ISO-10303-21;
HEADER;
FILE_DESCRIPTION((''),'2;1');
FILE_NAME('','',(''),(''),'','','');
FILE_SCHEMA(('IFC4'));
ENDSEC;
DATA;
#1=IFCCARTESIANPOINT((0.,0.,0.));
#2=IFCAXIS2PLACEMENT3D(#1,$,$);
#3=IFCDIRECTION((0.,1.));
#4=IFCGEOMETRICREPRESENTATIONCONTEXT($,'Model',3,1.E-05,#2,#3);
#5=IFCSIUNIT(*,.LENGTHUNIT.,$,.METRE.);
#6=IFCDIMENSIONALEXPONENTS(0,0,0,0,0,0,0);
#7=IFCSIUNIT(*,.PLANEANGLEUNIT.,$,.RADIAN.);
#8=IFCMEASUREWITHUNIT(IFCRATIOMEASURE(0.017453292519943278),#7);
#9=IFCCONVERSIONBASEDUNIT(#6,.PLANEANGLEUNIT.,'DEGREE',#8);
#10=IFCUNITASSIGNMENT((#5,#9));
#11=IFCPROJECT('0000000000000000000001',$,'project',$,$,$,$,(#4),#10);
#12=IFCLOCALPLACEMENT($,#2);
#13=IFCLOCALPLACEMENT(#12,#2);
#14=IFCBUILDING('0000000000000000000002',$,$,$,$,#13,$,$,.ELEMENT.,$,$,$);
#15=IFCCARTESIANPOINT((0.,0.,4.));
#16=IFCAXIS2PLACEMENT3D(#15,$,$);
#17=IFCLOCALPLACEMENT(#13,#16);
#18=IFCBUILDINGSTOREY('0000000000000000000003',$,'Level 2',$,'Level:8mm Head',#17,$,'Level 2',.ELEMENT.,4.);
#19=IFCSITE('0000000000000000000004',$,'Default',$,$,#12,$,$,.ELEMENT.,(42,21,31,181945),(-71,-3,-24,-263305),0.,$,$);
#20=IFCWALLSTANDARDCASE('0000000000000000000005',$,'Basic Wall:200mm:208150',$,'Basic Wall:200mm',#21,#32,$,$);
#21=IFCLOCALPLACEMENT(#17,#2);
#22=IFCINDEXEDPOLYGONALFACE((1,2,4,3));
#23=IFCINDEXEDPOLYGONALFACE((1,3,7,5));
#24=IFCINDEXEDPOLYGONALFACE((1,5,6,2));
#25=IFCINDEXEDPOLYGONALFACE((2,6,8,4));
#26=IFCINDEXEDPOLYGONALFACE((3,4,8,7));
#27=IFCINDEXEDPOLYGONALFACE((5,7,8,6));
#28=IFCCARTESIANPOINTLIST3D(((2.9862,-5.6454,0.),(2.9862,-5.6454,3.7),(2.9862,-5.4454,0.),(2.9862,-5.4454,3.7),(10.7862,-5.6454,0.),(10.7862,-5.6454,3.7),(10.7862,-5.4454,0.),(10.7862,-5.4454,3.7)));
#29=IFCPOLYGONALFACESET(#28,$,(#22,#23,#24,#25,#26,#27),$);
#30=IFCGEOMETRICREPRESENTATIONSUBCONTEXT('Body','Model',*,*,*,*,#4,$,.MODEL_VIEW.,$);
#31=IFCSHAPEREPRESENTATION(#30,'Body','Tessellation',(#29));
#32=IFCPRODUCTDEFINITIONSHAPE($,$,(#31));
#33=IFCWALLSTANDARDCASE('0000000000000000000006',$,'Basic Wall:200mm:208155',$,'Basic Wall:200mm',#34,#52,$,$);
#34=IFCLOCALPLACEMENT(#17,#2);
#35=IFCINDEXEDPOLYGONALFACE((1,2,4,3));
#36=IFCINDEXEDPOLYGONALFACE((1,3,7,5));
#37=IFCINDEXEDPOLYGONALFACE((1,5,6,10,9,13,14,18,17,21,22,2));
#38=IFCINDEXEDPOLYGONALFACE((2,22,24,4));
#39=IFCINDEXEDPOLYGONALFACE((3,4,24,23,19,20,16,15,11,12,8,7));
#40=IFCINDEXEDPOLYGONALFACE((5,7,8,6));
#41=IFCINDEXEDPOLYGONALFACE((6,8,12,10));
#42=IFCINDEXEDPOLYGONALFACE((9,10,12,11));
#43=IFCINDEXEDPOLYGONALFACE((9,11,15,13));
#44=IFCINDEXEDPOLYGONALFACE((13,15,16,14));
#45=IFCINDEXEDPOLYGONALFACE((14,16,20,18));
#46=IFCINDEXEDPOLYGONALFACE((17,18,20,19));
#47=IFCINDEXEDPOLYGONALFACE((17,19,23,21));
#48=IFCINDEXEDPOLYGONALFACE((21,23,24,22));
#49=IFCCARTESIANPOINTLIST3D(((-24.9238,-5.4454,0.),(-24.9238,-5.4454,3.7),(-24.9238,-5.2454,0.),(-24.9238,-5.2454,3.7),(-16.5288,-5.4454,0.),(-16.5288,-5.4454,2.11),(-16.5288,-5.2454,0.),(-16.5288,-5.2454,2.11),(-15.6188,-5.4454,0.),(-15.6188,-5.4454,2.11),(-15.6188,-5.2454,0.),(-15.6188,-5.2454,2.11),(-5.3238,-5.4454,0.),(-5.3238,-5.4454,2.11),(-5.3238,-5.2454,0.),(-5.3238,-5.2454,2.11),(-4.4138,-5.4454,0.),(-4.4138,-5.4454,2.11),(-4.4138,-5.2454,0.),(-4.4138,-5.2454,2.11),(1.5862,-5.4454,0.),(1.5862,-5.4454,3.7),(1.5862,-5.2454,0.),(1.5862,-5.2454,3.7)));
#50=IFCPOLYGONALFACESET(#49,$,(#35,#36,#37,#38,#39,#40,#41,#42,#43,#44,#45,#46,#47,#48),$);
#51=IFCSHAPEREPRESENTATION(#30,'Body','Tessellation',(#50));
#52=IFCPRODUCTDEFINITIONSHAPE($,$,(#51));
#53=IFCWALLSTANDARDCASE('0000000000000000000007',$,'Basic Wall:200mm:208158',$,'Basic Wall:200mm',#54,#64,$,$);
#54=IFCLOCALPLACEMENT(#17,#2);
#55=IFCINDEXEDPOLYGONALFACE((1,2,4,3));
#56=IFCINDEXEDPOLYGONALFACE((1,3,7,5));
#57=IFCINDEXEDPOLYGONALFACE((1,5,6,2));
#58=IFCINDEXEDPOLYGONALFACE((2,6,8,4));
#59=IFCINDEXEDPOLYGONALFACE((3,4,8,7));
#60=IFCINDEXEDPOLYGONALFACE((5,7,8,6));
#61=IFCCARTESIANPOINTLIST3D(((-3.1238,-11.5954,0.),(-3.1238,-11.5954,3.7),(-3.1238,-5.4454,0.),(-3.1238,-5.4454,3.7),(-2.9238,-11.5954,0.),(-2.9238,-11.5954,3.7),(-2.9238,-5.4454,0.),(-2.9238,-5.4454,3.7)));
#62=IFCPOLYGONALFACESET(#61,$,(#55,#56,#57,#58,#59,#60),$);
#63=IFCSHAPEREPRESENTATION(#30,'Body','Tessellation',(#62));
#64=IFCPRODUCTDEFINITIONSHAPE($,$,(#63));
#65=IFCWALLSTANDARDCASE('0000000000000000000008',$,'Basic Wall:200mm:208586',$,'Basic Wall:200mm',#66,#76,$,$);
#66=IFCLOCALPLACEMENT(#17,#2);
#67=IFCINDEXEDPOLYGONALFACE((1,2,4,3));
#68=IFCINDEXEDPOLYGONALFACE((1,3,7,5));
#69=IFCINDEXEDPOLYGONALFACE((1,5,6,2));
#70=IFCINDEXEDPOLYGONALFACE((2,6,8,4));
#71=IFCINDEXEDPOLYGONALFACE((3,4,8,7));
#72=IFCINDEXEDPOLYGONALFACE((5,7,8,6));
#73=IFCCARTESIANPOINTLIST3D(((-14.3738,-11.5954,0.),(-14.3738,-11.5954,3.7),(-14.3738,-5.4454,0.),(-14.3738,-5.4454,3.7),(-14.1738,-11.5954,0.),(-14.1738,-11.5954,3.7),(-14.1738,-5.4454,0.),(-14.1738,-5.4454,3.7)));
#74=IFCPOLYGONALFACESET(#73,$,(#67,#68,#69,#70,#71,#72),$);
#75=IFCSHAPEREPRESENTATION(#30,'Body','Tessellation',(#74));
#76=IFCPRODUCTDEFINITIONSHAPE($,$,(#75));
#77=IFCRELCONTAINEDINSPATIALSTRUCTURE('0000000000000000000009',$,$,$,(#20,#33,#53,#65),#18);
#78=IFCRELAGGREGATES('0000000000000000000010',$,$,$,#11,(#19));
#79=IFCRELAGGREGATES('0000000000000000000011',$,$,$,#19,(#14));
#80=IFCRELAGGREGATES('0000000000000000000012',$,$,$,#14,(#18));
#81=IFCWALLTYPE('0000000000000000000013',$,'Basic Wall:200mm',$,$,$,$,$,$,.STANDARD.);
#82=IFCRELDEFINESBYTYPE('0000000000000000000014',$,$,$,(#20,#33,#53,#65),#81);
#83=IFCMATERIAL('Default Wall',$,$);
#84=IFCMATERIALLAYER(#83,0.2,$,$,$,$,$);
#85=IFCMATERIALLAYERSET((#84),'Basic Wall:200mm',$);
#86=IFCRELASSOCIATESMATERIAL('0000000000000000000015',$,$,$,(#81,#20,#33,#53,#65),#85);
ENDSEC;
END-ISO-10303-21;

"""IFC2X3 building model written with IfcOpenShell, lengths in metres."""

from ifc_helpers import new_model, entity, si_unit, converted_unit, direction, frame, frame_2d, origin, place, context, subcontext, project, spatial, polyline, rectangle, extrude, clip, bounded_halfspace, material, layer, layer_set, layer_usage, type_object, element, save


model = new_model("IFC2X3")

# Units and contexts
model_context = context("Model", 3, precision=1e-05, world=origin(), true_north=direction((0.0, 1.0)))
body_context = subcontext(model_context, "Body", "Model", "MODEL_VIEW")
ifc_project = project(units=[si_unit("LENGTHUNIT", "METRE"), converted_unit("PLANEANGLEUNIT", "DEGREE", entity("IfcRatioMeasure", 0.017453292519943278), si_unit("PLANEANGLEUNIT", "RADIAN"), dimensions=[0, 0, 0, 0, 0, 0, 0])], contexts=[model_context])

# Site, building, storey
site_placement = place(None, origin())
site = spatial("IfcSite", under=ifc_project, at=site_placement, Name="Default", CompositionType="ELEMENT", RefLatitude=(42, 21, 31, 181945), RefLongitude=(-71, -3, -24, -263305), RefElevation=0.0)
building_placement = place(site_placement, origin())
building = spatial("IfcBuilding", under=site, at=building_placement, CompositionType="ELEMENT")
storey_placement = place(building_placement, frame((0.0, 0.0, 4.0)))
storey = spatial("IfcBuildingStorey", under=building, at=storey_placement, Name="Level 2", ObjectType="Level:8mm Head", LongName="Level 2", CompositionType="ELEMENT", Elevation=4.0)

# Shared definitions
ifc_material_1 = material(Name="Default Wall")
ifc_layer_1 = layer(ifc_material_1, 0.2)
ifc_layer_set_1 = layer_set([ifc_layer_1], Name="Basic Wall:200mm")
wall_type_1 = type_object("IfcWallType", Name="Basic Wall:200mm", PredefinedType="STANDARD", material=ifc_layer_set_1)

# Wall
ifc_layer_usage_1 = layer_usage(ifc_layer_set_1, "AXIS2", "NEGATIVE", 0.1)
wall_1_placement = place(storey_placement, frame((2.9862, -5.5454, 0.0)))
element("IfcWallStandardCase", 1, at=wall_1_placement, inside=storey, type_object=wall_type_1, material=ifc_layer_usage_1, Name="Basic Wall:200mm:208150", ObjectType="Basic Wall:200mm", context=body_context, shape_type="Clipping", body=[
    clip(extrude(rectangle(XDim=7.8, YDim=0.2, at=frame_2d((3.9, 0.0), x_axis=(-1.0, 0.0))), origin(), (0.0, 0.0, 1.0), 3.7), bounded_halfspace(frame((0.0, -0.1, 3.7), z_axis=(0.0, 0.0, -1.0), x_axis=(0.0, -1.0, 0.0)), True, frame((0.0, -0.1, 3.7), z_axis=(0.0, 0.0, -1.0), x_axis=(0.0, -1.0, 0.0)), polyline([(0.0, 0.0), (-0.2, 0.0), (-0.2, -7.8), (0.0, -7.8), (0.0, 0.0)]))),
])

# Wall, openings
ifc_layer_usage_2 = layer_usage(ifc_layer_set_1, "AXIS2", "NEGATIVE", 0.1)
wall_2_placement = place(storey_placement, frame((1.5862, -5.3454, 0.0), z_axis=(0.0, 0.0, 1.0), x_axis=(-1.0, 0.0, 0.0)))
wall_2 = element("IfcWallStandardCase", 2, at=wall_2_placement, inside=storey, type_object=wall_type_1, material=ifc_layer_usage_2, Name="Basic Wall:200mm:208155", ObjectType="Basic Wall:200mm", context=body_context, shape_type="Clipping", body=[
    clip(extrude(rectangle(XDim=26.51, YDim=0.2, at=frame_2d((13.255, 0.0), x_axis=(-1.0, 0.0))), origin(), (0.0, 0.0, 1.0), 3.7), bounded_halfspace(frame((0.0, -0.1, 3.7), z_axis=(0.0, 0.0, -1.0), x_axis=(0.0, 1.0, 0.0)), True, frame((0.0, -0.1, 3.7), z_axis=(0.0, 0.0, -1.0), x_axis=(0.0, 1.0, 0.0)), polyline([(0.0, 0.0), (0.2, 0.0), (0.2, 4.51), (0.2, 4.71), (0.2, 26.51), (0.0, 26.51), (0.0, 0.0)]))),
])
opening_1_placement = place(wall_2_placement, frame((6.0, -0.1, 0.0)))
element("IfcOpeningElement", 3, at=opening_1_placement, cuts=wall_2, ObjectType="Opening", context=body_context, shape_type="SweptSolid", body=[
    extrude(rectangle(XDim=2.11, YDim=0.91, at=frame_2d((1.055, 0.455), x_axis=(1.0, 0.0))), frame((0.0, 0.0, 0.0), z_axis=(0.0, 1.0, 0.0), x_axis=(0.0, 0.0, 1.0)), (0.0, 0.0, 1.0), 0.2),
])
opening_2_placement = place(wall_2_placement, frame((17.205, -0.1, 0.0)))
element("IfcOpeningElement", 4, at=opening_2_placement, cuts=wall_2, ObjectType="Opening", context=body_context, shape_type="SweptSolid", body=[
    extrude(rectangle(XDim=2.11, YDim=0.91, at=frame_2d((1.055, 0.455), x_axis=(1.0, 0.0))), frame((0.0, 0.0, 0.0), z_axis=(0.0, 1.0, 0.0), x_axis=(0.0, 0.0, 1.0)), (0.0, 0.0, 1.0), 0.2),
])

# Walls
ifc_layer_usage_3 = layer_usage(ifc_layer_set_1, "AXIS2", "NEGATIVE", 0.1)
wall_3_placement = place(storey_placement, frame((-3.0238, -5.4454, 0.0), z_axis=(0.0, 0.0, 1.0), x_axis=(0.0, -1.0, 0.0)))
element("IfcWallStandardCase", 5, at=wall_3_placement, inside=storey, type_object=wall_type_1, material=ifc_layer_usage_3, Name="Basic Wall:200mm:208158", ObjectType="Basic Wall:200mm", context=body_context, shape_type="Clipping", body=[
    clip(extrude(rectangle(XDim=6.15, YDim=0.2, at=frame_2d((3.075, 0.0), x_axis=(-1.0, 0.0))), origin(), (0.0, 0.0, 1.0), 3.7), bounded_halfspace(frame((0.0, -0.1, 3.7), z_axis=(0.0, 0.0, -1.0), x_axis=(1.0, 0.0, 0.0)), True, frame((0.0, -0.1, 3.7), z_axis=(0.0, 0.0, -1.0), x_axis=(1.0, 0.0, 0.0)), polyline([(0.0, 0.0), (0.0, -0.2), (2.7, -0.2), (2.9, -0.2), (6.15, -0.2), (6.15, 0.0), (0.0, 0.0)]))),
])
ifc_layer_usage_4 = layer_usage(ifc_layer_set_1, "AXIS2", "NEGATIVE", 0.1)
wall_4_placement = place(storey_placement, frame((-14.2738, -5.4454, 0.0), z_axis=(0.0, 0.0, 1.0), x_axis=(0.0, -1.0, 0.0)))
element("IfcWallStandardCase", 6, at=wall_4_placement, inside=storey, type_object=wall_type_1, material=ifc_layer_usage_4, Name="Basic Wall:200mm:208586", ObjectType="Basic Wall:200mm", context=body_context, shape_type="Clipping", body=[
    clip(extrude(rectangle(XDim=6.15, YDim=0.2, at=frame_2d((3.075, 0.0), x_axis=(-1.0, 0.0))), origin(), (0.0, 0.0, 1.0), 3.7), bounded_halfspace(frame((0.0, -0.1, 3.7), z_axis=(0.0, 0.0, -1.0), x_axis=(1.0, 0.0, 0.0)), True, frame((0.0, -0.1, 3.7), z_axis=(0.0, 0.0, -1.0), x_axis=(1.0, 0.0, 0.0)), polyline([(0.0, 0.0), (0.0, -0.2), (6.15, -0.2), (6.15, 0.0), (0.0, 0.0)]))),
])

save(model, "model.ifc")
